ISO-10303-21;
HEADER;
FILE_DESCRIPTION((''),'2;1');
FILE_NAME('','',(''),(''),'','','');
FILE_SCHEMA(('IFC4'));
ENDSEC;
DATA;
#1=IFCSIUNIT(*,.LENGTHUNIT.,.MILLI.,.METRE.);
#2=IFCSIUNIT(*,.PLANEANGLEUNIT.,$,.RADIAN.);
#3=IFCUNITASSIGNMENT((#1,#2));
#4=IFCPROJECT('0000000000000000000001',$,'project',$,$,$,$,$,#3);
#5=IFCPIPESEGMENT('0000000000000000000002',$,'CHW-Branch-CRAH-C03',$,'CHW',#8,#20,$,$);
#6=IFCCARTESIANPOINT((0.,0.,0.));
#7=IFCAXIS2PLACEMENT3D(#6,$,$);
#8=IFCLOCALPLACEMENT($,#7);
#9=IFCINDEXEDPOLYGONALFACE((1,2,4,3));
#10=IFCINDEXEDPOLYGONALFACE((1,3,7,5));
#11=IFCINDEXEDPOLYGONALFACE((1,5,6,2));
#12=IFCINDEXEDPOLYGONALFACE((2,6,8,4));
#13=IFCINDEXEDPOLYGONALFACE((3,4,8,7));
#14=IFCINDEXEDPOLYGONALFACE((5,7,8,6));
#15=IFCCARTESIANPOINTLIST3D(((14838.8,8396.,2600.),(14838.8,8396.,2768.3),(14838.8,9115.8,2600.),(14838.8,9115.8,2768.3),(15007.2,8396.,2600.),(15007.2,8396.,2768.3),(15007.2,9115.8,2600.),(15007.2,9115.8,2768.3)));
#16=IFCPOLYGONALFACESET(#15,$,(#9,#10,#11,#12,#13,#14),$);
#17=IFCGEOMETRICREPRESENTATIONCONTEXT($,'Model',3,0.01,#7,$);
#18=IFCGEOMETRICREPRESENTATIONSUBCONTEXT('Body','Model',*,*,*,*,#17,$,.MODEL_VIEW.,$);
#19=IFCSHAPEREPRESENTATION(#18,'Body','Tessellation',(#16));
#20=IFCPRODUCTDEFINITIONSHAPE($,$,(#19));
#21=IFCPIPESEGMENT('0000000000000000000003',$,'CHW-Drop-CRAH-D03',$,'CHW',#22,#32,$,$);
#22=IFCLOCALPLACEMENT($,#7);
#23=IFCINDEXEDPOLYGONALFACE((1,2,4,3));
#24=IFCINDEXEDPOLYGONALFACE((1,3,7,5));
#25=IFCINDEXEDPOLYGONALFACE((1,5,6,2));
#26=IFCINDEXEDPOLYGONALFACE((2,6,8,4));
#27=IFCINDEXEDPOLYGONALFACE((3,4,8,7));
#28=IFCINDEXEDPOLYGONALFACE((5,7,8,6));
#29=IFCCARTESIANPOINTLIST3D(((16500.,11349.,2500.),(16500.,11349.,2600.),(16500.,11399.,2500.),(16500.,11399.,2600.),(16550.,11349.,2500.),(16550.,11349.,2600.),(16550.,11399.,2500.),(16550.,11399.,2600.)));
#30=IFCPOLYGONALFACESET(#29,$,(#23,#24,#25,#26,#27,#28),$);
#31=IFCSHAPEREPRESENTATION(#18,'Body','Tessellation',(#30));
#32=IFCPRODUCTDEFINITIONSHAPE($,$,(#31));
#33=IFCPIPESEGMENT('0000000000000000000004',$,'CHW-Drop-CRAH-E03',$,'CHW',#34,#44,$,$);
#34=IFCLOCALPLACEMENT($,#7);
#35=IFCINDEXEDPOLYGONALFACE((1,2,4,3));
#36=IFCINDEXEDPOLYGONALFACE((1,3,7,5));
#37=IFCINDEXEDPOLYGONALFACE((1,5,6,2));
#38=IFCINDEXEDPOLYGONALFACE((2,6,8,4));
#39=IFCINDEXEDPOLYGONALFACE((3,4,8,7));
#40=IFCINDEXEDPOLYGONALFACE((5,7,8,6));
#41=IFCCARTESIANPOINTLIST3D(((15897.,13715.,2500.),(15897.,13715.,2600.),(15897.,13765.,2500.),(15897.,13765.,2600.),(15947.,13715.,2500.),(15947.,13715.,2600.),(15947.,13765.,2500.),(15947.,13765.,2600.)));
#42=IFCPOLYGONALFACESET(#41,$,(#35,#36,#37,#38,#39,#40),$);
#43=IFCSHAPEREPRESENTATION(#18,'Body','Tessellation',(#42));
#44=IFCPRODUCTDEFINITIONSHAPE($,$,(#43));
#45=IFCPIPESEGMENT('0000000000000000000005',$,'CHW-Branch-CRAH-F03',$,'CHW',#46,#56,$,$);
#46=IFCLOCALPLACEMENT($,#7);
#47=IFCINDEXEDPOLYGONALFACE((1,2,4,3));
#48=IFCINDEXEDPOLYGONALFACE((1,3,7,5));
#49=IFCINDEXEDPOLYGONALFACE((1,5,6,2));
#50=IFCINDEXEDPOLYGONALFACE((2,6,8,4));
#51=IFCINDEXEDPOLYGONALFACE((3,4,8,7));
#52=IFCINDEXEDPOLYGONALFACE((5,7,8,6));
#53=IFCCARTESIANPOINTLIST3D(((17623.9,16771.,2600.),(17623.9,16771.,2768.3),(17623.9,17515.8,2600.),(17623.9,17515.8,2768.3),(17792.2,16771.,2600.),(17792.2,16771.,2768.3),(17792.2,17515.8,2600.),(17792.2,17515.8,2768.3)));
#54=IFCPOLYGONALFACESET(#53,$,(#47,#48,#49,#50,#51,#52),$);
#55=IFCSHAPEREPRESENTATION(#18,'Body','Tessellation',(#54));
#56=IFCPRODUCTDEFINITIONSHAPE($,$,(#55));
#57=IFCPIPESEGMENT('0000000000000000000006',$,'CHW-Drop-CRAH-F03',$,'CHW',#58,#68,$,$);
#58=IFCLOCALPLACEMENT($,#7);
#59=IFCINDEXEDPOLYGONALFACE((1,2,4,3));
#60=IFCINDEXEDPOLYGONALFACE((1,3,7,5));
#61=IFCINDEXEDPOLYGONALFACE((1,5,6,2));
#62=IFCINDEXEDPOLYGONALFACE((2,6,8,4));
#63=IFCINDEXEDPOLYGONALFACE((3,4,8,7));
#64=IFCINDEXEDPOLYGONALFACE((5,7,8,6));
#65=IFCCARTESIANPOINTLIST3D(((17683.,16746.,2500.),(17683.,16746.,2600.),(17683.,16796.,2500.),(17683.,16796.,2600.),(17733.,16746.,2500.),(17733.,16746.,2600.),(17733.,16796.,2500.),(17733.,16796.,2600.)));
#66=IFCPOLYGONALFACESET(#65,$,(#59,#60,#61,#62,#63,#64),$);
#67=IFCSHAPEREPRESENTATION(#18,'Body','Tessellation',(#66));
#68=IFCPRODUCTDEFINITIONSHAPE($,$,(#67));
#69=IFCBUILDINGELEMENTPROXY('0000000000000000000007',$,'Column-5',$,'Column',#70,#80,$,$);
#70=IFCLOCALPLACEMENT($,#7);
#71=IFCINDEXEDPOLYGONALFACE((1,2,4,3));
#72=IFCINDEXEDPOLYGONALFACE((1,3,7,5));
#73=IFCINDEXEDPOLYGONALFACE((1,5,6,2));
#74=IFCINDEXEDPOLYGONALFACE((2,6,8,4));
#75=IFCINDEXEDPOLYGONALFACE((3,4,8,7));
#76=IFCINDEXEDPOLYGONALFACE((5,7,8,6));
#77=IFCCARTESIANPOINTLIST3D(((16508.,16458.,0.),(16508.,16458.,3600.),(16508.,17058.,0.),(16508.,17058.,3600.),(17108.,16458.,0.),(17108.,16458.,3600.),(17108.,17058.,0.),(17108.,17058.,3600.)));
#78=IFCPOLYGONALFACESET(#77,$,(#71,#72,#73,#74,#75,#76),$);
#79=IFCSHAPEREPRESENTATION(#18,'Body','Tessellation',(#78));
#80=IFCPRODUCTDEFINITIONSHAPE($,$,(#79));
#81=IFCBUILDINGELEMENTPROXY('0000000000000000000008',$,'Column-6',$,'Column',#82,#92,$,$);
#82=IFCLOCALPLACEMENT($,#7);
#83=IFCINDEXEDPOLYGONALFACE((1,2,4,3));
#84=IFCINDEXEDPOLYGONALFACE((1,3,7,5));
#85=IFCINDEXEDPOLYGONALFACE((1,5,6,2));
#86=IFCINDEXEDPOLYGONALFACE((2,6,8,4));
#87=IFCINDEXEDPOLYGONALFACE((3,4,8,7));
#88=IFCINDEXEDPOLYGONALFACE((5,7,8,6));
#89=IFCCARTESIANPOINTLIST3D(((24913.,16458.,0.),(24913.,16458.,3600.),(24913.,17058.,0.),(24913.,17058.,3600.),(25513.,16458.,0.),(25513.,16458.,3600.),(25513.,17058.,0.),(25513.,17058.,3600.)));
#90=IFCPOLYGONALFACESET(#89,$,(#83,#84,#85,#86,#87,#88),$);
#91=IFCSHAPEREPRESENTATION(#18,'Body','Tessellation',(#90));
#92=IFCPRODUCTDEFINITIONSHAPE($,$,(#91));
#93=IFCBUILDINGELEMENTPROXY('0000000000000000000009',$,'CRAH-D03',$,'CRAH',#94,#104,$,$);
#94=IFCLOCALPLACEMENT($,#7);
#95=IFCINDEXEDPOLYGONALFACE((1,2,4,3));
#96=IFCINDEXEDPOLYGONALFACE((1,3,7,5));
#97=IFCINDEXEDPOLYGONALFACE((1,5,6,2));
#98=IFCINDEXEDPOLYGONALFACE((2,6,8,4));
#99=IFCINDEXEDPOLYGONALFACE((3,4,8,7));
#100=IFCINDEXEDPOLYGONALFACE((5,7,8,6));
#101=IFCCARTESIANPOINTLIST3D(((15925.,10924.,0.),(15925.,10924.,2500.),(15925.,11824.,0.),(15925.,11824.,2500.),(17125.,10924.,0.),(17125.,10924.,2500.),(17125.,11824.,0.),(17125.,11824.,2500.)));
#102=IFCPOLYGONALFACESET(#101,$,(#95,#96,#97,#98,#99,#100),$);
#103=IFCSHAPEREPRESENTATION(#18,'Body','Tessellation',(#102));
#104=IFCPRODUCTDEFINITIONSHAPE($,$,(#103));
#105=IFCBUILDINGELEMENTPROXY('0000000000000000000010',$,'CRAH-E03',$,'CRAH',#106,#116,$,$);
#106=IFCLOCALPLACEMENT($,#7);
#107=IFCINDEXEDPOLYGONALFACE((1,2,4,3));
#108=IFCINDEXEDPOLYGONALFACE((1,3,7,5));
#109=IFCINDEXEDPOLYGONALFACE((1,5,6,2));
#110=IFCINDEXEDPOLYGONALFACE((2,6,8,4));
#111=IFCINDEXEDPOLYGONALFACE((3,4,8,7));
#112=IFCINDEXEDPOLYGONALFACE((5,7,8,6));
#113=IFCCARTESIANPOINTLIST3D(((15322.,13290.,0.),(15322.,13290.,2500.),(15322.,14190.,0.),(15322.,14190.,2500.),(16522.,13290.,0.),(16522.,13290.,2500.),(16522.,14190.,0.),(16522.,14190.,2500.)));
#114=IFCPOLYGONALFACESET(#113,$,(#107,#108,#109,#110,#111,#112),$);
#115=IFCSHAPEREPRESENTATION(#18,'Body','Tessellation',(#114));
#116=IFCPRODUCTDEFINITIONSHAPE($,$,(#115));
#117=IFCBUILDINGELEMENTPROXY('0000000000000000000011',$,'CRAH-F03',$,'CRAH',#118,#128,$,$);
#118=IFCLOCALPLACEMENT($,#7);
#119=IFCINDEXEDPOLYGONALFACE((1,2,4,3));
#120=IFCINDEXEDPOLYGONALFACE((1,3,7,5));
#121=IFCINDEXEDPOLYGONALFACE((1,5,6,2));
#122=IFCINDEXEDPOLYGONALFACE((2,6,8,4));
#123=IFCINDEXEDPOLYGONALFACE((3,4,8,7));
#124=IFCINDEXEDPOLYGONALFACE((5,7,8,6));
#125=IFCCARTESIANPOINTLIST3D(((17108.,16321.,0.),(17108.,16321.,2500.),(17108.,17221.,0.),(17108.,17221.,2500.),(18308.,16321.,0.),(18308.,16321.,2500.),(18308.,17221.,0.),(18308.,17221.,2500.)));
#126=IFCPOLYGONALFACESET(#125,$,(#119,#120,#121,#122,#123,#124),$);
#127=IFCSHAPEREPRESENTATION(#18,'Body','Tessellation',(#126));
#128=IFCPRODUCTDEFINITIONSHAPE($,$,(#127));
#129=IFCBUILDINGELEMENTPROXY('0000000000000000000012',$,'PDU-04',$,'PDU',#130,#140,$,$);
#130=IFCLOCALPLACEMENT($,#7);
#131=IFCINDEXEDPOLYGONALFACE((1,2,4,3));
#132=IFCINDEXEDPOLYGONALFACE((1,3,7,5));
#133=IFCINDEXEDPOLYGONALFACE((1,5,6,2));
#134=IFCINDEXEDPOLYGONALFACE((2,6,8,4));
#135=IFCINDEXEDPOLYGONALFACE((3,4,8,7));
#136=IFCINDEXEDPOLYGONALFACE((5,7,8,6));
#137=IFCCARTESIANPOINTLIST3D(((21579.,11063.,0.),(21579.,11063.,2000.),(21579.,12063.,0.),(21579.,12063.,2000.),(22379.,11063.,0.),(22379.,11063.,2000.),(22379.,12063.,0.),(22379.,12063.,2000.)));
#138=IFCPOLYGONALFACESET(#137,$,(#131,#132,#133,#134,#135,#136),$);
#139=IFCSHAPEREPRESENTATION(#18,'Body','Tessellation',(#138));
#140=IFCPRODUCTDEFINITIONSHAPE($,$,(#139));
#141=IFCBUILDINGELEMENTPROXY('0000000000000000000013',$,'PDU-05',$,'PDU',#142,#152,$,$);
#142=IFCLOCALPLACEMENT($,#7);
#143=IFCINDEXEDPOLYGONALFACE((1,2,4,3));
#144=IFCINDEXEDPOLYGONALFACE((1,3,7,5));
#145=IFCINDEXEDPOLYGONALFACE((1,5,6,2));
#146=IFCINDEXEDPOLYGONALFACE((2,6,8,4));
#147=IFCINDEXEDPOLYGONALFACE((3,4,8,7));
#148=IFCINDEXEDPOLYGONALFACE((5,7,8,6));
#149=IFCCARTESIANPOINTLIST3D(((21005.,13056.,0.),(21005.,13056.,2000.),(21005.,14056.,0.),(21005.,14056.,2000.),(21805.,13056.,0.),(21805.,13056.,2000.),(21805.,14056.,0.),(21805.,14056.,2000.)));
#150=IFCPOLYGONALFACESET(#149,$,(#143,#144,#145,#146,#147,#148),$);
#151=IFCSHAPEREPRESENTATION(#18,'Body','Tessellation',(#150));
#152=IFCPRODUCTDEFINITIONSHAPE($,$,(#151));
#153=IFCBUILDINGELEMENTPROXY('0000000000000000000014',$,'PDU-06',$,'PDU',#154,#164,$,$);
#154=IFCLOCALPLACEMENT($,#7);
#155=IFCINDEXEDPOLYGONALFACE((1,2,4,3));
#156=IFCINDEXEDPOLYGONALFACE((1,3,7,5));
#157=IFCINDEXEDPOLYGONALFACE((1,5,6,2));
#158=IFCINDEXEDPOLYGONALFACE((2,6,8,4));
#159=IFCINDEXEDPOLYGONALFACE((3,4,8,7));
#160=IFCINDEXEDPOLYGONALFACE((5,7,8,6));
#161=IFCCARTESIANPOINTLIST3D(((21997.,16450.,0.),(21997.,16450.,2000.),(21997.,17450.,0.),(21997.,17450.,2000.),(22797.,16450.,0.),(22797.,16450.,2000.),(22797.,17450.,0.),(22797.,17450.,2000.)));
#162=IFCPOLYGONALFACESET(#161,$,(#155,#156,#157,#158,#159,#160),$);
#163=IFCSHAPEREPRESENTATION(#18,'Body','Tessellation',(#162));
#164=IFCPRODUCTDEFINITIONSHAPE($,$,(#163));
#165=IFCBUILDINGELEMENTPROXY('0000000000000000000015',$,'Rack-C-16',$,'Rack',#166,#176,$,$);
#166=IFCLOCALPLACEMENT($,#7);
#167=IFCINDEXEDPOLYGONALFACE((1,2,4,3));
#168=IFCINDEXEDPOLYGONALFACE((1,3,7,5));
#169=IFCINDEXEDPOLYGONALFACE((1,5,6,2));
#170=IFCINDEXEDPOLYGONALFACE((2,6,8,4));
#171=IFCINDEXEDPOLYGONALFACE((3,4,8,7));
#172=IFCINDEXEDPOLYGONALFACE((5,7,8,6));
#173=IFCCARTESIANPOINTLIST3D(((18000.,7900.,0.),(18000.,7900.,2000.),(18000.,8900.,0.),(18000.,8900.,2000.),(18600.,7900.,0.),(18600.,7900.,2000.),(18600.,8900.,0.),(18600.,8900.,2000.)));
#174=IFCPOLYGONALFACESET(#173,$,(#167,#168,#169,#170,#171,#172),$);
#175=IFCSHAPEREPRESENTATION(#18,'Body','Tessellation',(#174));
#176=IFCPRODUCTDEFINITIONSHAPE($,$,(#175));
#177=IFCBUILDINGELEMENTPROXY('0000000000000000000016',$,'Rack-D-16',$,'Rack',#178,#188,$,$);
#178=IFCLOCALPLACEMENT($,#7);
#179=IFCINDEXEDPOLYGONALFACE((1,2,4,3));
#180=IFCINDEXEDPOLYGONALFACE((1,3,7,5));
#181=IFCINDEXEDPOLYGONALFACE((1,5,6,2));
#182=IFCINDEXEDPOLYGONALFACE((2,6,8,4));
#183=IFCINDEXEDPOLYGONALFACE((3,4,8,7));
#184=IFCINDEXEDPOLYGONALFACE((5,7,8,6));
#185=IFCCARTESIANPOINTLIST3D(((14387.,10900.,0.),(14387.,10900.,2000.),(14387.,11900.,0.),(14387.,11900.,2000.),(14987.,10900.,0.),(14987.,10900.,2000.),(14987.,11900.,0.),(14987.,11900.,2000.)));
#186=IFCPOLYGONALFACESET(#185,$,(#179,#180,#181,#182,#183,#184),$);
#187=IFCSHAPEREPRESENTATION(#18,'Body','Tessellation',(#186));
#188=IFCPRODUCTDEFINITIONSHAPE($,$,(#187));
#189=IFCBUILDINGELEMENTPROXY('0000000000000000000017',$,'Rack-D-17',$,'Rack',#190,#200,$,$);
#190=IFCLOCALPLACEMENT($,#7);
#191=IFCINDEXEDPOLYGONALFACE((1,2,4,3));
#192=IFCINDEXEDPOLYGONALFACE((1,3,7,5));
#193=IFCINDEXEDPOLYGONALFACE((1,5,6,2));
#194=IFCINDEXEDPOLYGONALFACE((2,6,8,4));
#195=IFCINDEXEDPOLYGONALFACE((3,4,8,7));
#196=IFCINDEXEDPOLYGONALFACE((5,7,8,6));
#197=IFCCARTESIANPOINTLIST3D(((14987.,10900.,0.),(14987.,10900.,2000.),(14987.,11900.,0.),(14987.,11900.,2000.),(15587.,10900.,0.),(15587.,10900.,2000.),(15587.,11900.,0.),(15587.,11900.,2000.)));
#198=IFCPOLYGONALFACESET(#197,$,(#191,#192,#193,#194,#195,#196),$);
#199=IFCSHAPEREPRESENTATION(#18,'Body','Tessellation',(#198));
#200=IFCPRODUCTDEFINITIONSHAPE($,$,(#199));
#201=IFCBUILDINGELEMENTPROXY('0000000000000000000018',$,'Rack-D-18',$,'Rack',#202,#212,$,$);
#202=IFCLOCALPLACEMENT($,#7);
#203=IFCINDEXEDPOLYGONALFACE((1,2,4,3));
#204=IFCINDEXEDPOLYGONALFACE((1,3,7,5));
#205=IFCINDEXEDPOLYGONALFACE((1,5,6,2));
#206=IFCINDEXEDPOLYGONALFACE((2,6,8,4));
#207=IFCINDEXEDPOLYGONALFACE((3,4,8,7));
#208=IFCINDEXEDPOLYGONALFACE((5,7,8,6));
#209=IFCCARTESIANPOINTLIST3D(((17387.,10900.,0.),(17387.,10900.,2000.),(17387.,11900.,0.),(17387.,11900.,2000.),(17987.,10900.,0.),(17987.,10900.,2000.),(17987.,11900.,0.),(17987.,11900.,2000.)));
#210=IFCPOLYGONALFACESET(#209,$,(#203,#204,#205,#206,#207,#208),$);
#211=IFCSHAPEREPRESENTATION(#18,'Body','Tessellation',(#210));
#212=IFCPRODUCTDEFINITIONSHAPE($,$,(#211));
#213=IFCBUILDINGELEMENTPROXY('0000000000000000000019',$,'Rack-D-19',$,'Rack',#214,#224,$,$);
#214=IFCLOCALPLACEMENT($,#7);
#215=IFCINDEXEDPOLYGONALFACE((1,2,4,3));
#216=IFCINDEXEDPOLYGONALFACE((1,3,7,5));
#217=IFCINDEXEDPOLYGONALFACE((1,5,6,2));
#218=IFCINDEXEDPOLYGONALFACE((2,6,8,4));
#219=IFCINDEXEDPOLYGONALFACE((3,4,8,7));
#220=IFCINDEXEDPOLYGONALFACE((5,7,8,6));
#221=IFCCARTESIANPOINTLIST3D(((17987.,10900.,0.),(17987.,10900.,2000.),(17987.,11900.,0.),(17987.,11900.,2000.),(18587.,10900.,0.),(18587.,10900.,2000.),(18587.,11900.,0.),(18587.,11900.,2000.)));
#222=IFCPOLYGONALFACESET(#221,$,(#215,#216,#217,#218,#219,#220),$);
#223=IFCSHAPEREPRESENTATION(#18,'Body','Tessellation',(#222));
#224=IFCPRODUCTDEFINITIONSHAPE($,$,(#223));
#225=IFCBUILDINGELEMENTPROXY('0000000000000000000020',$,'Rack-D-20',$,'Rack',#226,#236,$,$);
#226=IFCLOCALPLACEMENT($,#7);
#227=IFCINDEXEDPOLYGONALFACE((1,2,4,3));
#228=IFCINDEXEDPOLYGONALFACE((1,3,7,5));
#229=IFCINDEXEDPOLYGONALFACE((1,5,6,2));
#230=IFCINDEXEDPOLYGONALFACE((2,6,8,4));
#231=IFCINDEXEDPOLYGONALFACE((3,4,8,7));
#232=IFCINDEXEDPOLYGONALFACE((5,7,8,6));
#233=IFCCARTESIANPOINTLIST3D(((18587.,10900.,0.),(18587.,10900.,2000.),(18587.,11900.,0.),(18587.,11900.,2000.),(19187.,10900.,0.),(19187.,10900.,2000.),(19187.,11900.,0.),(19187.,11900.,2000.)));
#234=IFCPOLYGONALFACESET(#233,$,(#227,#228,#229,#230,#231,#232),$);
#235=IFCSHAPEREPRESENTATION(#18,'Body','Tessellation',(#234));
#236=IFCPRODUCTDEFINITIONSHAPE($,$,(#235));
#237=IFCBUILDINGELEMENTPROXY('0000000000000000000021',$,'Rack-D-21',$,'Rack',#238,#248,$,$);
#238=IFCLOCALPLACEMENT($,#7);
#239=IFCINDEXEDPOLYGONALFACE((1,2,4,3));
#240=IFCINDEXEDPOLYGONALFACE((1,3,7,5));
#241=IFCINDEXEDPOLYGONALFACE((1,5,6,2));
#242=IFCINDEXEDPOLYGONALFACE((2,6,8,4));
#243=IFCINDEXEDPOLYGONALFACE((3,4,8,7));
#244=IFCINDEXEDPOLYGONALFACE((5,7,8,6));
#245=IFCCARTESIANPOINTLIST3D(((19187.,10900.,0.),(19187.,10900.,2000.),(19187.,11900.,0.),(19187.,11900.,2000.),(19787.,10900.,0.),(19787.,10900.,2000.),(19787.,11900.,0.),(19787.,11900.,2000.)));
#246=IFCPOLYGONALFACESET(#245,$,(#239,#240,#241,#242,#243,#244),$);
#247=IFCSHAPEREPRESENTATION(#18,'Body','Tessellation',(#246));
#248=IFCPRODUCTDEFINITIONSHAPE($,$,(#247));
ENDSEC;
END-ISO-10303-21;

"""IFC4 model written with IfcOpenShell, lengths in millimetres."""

from ifc_helpers import new_model, si_unit, frame, origin, place, context, subcontext, project, rectangle, extrude, element, save


model = new_model("IFC4")

# Units and contexts
model_context = context("Model", 3, precision=0.01, world=origin())
body_context = subcontext(model_context, "Body", "Model", "MODEL_VIEW")
ifc_project = project(units=[si_unit("LENGTHUNIT", "METRE", prefix="MILLI"), si_unit("PLANEANGLEUNIT", "RADIAN")])

# Pipe segments
placement = place(None, origin())
pipe_segment_1_placement = place(placement, frame((14923.0, 8755.9, 2600.0)))
element("IfcPipeSegment", 1, at=pipe_segment_1_placement, Name="CHW-Branch-CRAH-C03", ObjectType="CHW", context=body_context, shape_type="SweptSolid", body=[
    extrude(rectangle(XDim=168.3, YDim=719.9), origin(), (0.0, 0.0, 1.0), 168.3),
])
for number, where, name in (
    (2, (16525.0, 11374.0, 2500.0), "CHW-Drop-CRAH-D03"),
    (3, (15922.0, 13740.0, 2500.0), "CHW-Drop-CRAH-E03"),
):
    element("IfcPipeSegment", number, at=place(placement, frame(where)), Name=name, ObjectType="CHW", context=body_context, shape_type="SweptSolid", body=[
        extrude(rectangle(XDim=50.0, YDim=50.0), origin(), (0.0, 0.0, 1.0), 100.0),
    ])
pipe_segment_2_placement = place(placement, frame((17708.0, 17143.4, 2600.0)))
element("IfcPipeSegment", 4, at=pipe_segment_2_placement, Name="CHW-Branch-CRAH-F03", ObjectType="CHW", context=body_context, shape_type="SweptSolid", body=[
    extrude(rectangle(XDim=168.3, YDim=744.8), origin(), (0.0, 0.0, 1.0), 168.3),
])
pipe_segment_3_placement = place(placement, frame((17708.0, 16771.0, 2500.0)))
element("IfcPipeSegment", 5, at=pipe_segment_3_placement, Name="CHW-Drop-CRAH-F03", ObjectType="CHW", context=body_context, shape_type="SweptSolid", body=[
    extrude(rectangle(XDim=50.0, YDim=50.0), origin(), (0.0, 0.0, 1.0), 100.0),
])

# Building element proxies
for number, where, name in (
    (6, (16808.0, 16758.0, 0.0), "Column-5"),
    (7, (25213.0, 16758.0, 0.0), "Column-6"),
):
    element("IfcBuildingElementProxy", number, at=place(placement, frame(where)), Name=name, ObjectType="Column", context=body_context, shape_type="SweptSolid", body=[
        extrude(rectangle(XDim=600.0, YDim=600.0), origin(), (0.0, 0.0, 1.0), 3600.0),
    ])
for number, where, name in (
    (8, (16525.0, 11374.0, 0.0), "CRAH-D03"),
    (9, (15922.0, 13740.0, 0.0), "CRAH-E03"),
    (10, (17708.0, 16771.0, 0.0), "CRAH-F03"),
):
    element("IfcBuildingElementProxy", number, at=place(placement, frame(where)), Name=name, ObjectType="CRAH", context=body_context, shape_type="SweptSolid", body=[
        extrude(rectangle(XDim=1200.0, YDim=900.0), origin(), (0.0, 0.0, 1.0), 2500.0),
    ])
for number, where, name in (
    (11, (21979.0, 11563.0, 0.0), "PDU-04"),
    (12, (21405.0, 13556.0, 0.0), "PDU-05"),
    (13, (22397.0, 16950.0, 0.0), "PDU-06"),
):
    element("IfcBuildingElementProxy", number, at=place(placement, frame(where)), Name=name, ObjectType="PDU", context=body_context, shape_type="SweptSolid", body=[
        extrude(rectangle(XDim=800.0, YDim=1000.0), origin(), (0.0, 0.0, 1.0), 2000.0),
    ])
for number, where, name in (
    (14, (18300.0, 8400.0, 0.0), "Rack-C-16"),
    (15, (14687.0, 11400.0, 0.0), "Rack-D-16"),
    (16, (15287.0, 11400.0, 0.0), "Rack-D-17"),
    (17, (17687.0, 11400.0, 0.0), "Rack-D-18"),
    (18, (18287.0, 11400.0, 0.0), "Rack-D-19"),
    (19, (18887.0, 11400.0, 0.0), "Rack-D-20"),
    (20, (19487.0, 11400.0, 0.0), "Rack-D-21"),
):
    element("IfcBuildingElementProxy", number, at=place(placement, frame(where)), Name=name, ObjectType="Rack", context=body_context, shape_type="SweptSolid", body=[
        extrude(rectangle(XDim=600.0, YDim=1000.0), origin(), (0.0, 0.0, 1.0), 2000.0),
    ])

save(model, "model.ifc")
